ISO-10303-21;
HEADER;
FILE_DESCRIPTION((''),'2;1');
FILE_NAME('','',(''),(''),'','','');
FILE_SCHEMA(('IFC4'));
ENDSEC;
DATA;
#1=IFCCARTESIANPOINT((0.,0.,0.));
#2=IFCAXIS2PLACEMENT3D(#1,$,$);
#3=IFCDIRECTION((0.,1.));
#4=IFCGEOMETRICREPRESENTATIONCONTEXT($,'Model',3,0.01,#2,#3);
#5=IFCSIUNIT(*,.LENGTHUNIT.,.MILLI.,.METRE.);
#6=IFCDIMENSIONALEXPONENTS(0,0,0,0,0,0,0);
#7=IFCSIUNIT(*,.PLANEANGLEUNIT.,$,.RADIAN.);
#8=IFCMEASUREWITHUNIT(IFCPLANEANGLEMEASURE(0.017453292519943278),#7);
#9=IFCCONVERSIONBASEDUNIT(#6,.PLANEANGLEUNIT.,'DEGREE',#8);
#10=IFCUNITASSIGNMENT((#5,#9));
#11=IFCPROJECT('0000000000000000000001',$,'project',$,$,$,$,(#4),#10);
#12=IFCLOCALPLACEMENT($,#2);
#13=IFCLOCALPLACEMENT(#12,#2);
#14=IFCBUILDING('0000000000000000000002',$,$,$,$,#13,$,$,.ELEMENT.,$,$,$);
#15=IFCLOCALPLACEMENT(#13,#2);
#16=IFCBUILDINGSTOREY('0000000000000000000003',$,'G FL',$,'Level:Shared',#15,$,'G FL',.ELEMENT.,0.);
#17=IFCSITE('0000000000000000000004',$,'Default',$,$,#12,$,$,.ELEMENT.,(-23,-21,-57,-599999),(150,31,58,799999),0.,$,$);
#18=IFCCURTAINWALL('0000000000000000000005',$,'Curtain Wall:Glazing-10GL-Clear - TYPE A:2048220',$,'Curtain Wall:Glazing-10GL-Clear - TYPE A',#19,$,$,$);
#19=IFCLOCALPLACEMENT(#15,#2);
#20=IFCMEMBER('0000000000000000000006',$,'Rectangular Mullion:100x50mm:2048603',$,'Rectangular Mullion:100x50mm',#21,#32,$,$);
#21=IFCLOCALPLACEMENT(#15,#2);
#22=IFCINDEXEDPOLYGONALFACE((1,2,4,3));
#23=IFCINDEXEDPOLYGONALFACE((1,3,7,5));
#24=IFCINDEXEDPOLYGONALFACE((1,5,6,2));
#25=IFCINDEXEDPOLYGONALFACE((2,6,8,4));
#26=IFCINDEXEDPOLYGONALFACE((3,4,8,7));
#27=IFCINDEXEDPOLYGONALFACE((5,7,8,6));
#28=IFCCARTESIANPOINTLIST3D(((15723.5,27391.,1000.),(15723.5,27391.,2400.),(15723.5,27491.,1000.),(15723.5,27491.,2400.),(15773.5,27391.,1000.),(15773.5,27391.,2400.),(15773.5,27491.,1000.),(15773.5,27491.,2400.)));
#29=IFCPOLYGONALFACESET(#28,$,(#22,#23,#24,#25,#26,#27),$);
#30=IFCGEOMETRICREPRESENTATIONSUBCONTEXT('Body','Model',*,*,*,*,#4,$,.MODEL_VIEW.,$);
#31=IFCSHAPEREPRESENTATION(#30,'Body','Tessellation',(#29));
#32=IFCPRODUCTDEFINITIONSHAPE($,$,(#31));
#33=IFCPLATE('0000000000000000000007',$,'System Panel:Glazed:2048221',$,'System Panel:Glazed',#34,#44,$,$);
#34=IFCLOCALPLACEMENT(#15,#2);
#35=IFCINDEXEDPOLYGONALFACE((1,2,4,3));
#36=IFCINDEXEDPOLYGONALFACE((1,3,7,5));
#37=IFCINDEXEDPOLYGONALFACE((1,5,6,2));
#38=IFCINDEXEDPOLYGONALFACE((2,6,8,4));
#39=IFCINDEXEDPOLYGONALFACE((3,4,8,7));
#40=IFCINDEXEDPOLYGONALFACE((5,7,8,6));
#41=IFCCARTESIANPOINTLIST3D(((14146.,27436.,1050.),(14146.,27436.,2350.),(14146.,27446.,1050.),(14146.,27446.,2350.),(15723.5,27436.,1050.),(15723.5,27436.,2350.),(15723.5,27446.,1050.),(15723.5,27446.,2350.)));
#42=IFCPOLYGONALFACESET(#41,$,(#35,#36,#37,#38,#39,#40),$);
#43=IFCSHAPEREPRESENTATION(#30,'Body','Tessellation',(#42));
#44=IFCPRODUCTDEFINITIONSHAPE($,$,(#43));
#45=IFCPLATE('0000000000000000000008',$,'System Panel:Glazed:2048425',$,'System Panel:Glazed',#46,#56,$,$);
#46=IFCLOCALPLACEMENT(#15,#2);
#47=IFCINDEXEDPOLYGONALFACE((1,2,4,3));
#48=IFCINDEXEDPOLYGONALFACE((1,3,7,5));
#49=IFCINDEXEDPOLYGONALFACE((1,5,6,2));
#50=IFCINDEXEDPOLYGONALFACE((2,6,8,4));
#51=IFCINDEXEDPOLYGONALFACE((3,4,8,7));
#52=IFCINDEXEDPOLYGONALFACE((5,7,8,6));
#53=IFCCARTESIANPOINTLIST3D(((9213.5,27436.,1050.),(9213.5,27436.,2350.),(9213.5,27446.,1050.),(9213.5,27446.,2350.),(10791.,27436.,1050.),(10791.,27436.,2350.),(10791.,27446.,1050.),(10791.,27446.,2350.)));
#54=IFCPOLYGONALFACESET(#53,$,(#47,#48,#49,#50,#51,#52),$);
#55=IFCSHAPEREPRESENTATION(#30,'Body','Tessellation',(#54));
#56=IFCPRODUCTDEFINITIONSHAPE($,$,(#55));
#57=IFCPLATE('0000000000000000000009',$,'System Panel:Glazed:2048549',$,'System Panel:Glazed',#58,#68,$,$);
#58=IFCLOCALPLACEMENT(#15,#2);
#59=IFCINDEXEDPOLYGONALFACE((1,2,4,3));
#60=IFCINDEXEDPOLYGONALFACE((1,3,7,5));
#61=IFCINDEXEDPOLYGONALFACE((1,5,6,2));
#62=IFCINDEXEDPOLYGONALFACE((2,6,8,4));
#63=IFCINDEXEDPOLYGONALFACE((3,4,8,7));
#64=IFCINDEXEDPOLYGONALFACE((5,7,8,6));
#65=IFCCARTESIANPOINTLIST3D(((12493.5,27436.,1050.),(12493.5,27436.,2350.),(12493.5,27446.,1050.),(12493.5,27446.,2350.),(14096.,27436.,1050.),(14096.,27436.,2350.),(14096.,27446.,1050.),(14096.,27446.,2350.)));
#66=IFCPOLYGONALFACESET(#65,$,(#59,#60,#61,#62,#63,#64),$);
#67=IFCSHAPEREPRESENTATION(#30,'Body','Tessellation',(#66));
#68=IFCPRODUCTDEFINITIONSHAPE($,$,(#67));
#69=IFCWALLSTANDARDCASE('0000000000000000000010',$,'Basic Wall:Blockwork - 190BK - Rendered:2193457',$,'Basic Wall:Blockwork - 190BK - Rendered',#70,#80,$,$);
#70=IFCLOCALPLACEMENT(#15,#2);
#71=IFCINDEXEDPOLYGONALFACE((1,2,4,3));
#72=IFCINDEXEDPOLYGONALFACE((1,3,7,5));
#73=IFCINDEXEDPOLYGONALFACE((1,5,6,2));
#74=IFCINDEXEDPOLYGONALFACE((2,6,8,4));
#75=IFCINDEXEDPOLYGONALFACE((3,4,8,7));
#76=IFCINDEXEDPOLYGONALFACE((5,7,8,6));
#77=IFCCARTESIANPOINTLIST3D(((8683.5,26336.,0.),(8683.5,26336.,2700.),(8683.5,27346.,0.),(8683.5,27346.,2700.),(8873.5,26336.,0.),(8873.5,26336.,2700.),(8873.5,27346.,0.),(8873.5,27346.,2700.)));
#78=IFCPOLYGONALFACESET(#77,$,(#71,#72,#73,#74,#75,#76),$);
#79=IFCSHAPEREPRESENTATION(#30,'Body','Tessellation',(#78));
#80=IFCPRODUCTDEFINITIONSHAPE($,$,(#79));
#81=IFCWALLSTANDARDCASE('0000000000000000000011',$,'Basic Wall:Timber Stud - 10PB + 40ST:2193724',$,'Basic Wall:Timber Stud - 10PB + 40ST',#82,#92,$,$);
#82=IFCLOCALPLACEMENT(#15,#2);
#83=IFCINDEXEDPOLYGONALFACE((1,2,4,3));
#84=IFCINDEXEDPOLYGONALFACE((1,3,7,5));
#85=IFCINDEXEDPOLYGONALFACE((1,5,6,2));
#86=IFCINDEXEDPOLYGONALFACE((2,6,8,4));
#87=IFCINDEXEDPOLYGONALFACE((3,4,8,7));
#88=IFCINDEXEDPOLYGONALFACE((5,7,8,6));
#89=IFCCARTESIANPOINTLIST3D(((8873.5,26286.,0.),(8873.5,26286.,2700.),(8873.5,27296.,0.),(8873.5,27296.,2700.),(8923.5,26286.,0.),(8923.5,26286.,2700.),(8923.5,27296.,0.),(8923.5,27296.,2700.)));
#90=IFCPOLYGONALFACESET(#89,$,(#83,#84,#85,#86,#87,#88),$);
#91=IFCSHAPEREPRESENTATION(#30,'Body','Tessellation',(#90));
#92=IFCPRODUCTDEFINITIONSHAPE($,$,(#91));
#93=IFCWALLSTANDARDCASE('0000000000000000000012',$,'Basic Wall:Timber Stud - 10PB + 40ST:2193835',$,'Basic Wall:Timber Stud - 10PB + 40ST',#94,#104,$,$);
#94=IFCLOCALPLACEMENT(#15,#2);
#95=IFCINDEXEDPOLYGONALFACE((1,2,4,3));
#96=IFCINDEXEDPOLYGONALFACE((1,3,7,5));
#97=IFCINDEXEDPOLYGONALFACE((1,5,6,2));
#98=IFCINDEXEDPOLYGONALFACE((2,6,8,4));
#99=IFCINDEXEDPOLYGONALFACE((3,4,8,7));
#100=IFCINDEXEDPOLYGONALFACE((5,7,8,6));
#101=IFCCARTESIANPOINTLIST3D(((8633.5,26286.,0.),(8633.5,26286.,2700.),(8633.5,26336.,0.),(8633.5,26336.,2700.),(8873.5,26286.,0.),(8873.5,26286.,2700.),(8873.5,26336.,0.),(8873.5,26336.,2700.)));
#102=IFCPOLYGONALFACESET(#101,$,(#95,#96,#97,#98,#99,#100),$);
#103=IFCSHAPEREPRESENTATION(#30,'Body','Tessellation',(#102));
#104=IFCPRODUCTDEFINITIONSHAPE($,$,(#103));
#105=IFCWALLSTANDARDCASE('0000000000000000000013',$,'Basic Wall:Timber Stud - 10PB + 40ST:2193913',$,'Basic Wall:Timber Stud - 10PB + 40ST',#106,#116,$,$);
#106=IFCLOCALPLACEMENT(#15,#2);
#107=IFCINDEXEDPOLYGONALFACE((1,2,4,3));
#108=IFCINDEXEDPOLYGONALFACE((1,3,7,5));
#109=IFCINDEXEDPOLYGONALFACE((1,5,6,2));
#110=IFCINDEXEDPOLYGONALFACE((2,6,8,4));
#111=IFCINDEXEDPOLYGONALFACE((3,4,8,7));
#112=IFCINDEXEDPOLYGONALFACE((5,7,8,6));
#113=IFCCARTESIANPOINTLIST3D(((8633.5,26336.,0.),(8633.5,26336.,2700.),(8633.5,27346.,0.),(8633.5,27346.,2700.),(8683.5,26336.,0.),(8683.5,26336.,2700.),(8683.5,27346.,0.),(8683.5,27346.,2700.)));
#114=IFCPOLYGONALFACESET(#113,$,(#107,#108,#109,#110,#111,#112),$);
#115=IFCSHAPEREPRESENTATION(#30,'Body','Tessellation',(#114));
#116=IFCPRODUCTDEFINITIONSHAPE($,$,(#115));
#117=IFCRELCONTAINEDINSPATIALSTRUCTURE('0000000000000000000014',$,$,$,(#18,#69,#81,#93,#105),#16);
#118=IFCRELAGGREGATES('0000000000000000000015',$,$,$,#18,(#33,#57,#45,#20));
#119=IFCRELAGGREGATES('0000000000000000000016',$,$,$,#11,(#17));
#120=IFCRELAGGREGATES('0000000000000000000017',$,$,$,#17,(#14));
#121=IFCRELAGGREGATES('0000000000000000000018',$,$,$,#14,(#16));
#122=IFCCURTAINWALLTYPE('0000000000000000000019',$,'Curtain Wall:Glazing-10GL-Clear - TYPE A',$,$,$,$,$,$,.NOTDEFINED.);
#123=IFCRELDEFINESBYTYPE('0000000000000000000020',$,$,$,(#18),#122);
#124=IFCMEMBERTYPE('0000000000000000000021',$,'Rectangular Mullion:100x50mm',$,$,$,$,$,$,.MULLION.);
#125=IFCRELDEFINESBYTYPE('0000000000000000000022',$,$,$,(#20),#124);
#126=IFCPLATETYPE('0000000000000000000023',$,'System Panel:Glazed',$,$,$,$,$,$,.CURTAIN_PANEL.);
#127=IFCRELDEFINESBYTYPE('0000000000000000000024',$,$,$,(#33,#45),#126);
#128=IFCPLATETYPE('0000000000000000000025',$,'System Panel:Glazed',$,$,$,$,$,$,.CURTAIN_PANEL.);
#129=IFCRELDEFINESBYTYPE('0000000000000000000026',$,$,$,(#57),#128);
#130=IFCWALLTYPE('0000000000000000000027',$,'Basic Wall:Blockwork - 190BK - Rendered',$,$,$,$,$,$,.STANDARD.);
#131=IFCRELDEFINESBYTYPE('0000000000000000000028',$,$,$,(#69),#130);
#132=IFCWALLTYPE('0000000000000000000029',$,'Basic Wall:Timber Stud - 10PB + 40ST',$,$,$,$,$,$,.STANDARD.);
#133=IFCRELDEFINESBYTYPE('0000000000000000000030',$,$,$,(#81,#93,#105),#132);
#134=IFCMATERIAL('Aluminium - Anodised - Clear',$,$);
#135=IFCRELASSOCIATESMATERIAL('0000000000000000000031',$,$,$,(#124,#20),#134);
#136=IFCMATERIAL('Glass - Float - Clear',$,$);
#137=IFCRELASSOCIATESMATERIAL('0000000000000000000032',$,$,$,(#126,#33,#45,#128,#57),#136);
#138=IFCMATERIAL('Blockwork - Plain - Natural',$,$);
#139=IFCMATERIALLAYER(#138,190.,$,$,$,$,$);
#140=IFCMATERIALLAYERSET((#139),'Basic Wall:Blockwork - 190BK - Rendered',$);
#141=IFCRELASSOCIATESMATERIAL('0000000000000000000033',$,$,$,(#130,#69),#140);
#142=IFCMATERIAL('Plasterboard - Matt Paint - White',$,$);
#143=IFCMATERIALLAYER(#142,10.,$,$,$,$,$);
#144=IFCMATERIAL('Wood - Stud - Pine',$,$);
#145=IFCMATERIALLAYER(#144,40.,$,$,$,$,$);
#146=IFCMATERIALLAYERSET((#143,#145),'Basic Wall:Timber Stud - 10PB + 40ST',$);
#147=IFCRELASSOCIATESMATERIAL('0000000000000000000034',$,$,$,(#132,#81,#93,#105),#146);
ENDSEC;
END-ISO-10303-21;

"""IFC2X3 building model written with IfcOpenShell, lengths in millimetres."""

from ifc_helpers import new_model, entity, si_unit, converted_unit, direction, frame, frame_2d, origin, origin_2d_with_axis, place, context, subcontext, project, spatial, rectangle, extrude, source, transform, mapped, material, layer, layer_set, layer_usage, type_object, type_shapes, element, aggregate, save


model = new_model("IFC2X3")

# Units and contexts
model_context = context("Model", 3, precision=0.01, world=origin(), true_north=direction((0.0, 1.0)))
body_context = subcontext(model_context, "Body", "Model", "MODEL_VIEW")
ifc_project = project(units=[si_unit("LENGTHUNIT", "METRE", prefix="MILLI"), converted_unit("PLANEANGLEUNIT", "DEGREE", entity("IfcPlaneAngleMeasure", 0.017453292519943278), si_unit("PLANEANGLEUNIT", "RADIAN"), dimensions=[0, 0, 0, 0, 0, 0, 0])], contexts=[model_context])

# Site, building, storey
site_placement = place(None, origin())
site = spatial("IfcSite", under=ifc_project, at=site_placement, Name="Default", CompositionType="ELEMENT", RefLatitude=(-23, -21, -57, -599999), RefLongitude=(150, 31, 58, 799999), RefElevation=0.0)
building_placement = place(site_placement, origin())
building = spatial("IfcBuilding", under=site, at=building_placement, CompositionType="ELEMENT")
storey_placement = place(building_placement, origin())
storey = spatial("IfcBuildingStorey", under=building, at=storey_placement, Name="G FL", ObjectType="Level:Shared", LongName="G FL", CompositionType="ELEMENT", Elevation=0.0)

# Curtain wall, member, plates
curtain_wall_type = type_object("IfcCurtainWallType", Name="Curtain Wall:Glazing-10GL-Clear - TYPE A", PredefinedType="NOTDEFINED")
curtain_wall_placement = place(storey_placement, origin())
curtain_wall = element("IfcCurtainWall", 1, at=curtain_wall_placement, inside=storey, type_object=curtain_wall_type, Name="Curtain Wall:Glazing-10GL-Clear - TYPE A:2048220", ObjectType="Curtain Wall:Glazing-10GL-Clear - TYPE A")
ifc_material_1 = material(Name="Aluminium - Anodised - Clear")
member_type_1 = type_object("IfcMemberType", Name="Rectangular Mullion:100x50mm", PredefinedType="MULLION", material=ifc_material_1)
shared_shape_1 = source(origin(), body_context, "Body", "SweptSolid", [
    extrude(rectangle(XDim=50.0, YDim=100.0, at=frame_2d((0.0, 0.0), x_axis=(1.0, 0.0))), frame((-25.0, 0.0, -1400.0), z_axis=(0.0, 0.0, 1.0), x_axis=(-1.0, 0.0, 0.0)), (0.0, 0.0, 1.0), 1400.0),
])
type_shapes(member_type_1, [shared_shape_1])
member_1_placement = place(curtain_wall_placement, frame((15773.5, 27441.0, 2400.0)))
member_1 = element("IfcMember", 2, at=member_1_placement, type_object=member_type_1, material=ifc_material_1, Name="Rectangular Mullion:100x50mm:2048603", ObjectType="Rectangular Mullion:100x50mm", context=body_context, shape_type="MappedRepresentation", body=[
    mapped(shared_shape_1, transform((0.0, 0.0, 0.0), scale=1.0)),
])
ifc_material_2 = material(Name="Glass - Float - Clear")
plate_type_1 = type_object("IfcPlateType", Name="System Panel:Glazed", PredefinedType="CURTAIN_PANEL", material=ifc_material_2)
shared_shape_2 = source(origin(), body_context, "Body", "SweptSolid", [
    extrude(rectangle(XDim=10.0, YDim=1577.5, at=origin_2d_with_axis()), frame((0.0, 0.0, 0.0), z_axis=(0.0, 0.0, 1.0), x_axis=(0.0, 1.0, 0.0)), (0.0, 0.0, 1.0), 1300.0),
])
type_shapes(plate_type_1, [shared_shape_2])
plate_1_placement = place(curtain_wall_placement, frame((14934.8, 27441.0, 1050.0), z_axis=(0.0, 0.0, 1.0), x_axis=(-1.0, 0.0, 0.0)))
plate_1 = element("IfcPlate", 3, at=plate_1_placement, type_object=plate_type_1, material=ifc_material_2, Name="System Panel:Glazed:2048221", ObjectType="System Panel:Glazed", context=body_context, shape_type="MappedRepresentation", body=[
    mapped(shared_shape_2, transform((0.0, 0.0, 0.0), scale=1.0)),
])
plate_2_placement = place(curtain_wall_placement, frame((10002.3, 27441.0, 1050.0), z_axis=(0.0, 0.0, 1.0), x_axis=(-1.0, 0.0, 0.0)))
plate_2 = element("IfcPlate", 4, at=plate_2_placement, type_object=plate_type_1, material=ifc_material_2, Name="System Panel:Glazed:2048425", ObjectType="System Panel:Glazed", context=body_context, shape_type="MappedRepresentation", body=[
    mapped(shared_shape_2, transform((0.0, 0.0, 0.0), scale=1.0)),
])
plate_type_2 = type_object("IfcPlateType", Name="System Panel:Glazed", PredefinedType="CURTAIN_PANEL", material=ifc_material_2)
shared_shape_3 = source(origin(), body_context, "Body", "SweptSolid", [
    extrude(rectangle(XDim=10.0, YDim=1602.5, at=origin_2d_with_axis()), frame((0.0, 0.0, 0.0), z_axis=(0.0, 0.0, 1.0), x_axis=(0.0, 1.0, 0.0)), (0.0, 0.0, 1.0), 1300.0),
])
type_shapes(plate_type_2, [shared_shape_3])
plate_3_placement = place(curtain_wall_placement, frame((13294.8, 27441.0, 1050.0), z_axis=(0.0, 0.0, 1.0), x_axis=(-1.0, 0.0, 0.0)))
plate_3 = element("IfcPlate", 5, at=plate_3_placement, type_object=plate_type_2, material=ifc_material_2, Name="System Panel:Glazed:2048549", ObjectType="System Panel:Glazed", context=body_context, shape_type="MappedRepresentation", body=[
    mapped(shared_shape_3, transform((0.0, 0.0, 0.0), scale=1.0)),
])
aggregate(curtain_wall, [plate_1, plate_3, plate_2, member_1])

# Walls
ifc_material_3 = material(Name="Blockwork - Plain - Natural")
ifc_layer_1 = layer(ifc_material_3, 190.0)
ifc_layer_set_1 = layer_set([ifc_layer_1], Name="Basic Wall:Blockwork - 190BK - Rendered")
ifc_layer_usage_1 = layer_usage(ifc_layer_set_1, "AXIS2", "POSITIVE", -95.0)
wall_type_1 = type_object("IfcWallType", Name="Basic Wall:Blockwork - 190BK - Rendered", PredefinedType="STANDARD", material=ifc_layer_set_1)
wall_1_placement = place(storey_placement, frame((8778.5, 27346.0, 0.0), z_axis=(0.0, 0.0, 1.0), x_axis=(0.0, -1.0, 0.0)))
element("IfcWallStandardCase", 6, at=wall_1_placement, inside=storey, type_object=wall_type_1, material=ifc_layer_usage_1, Name="Basic Wall:Blockwork - 190BK - Rendered:2193457", ObjectType="Basic Wall:Blockwork - 190BK - Rendered", context=body_context, shape_type="SweptSolid", body=[
    extrude(rectangle(XDim=1010.0, YDim=190.0, at=frame_2d((505.0, 0.0), x_axis=(-1.0, 0.0))), origin(), (0.0, 0.0, 1.0), 2700.0),
])
ifc_material_4 = material(Name="Plasterboard - Matt Paint - White")
ifc_layer_2 = layer(ifc_material_4, 10.0)
ifc_material_5 = material(Name="Wood - Stud - Pine")
ifc_layer_3 = layer(ifc_material_5, 40.0)
ifc_layer_set_2 = layer_set([ifc_layer_2, ifc_layer_3], Name="Basic Wall:Timber Stud - 10PB + 40ST")
ifc_layer_usage_2 = layer_usage(ifc_layer_set_2, "AXIS2", "POSITIVE", -25.0)
wall_type_2 = type_object("IfcWallType", Name="Basic Wall:Timber Stud - 10PB + 40ST", PredefinedType="STANDARD", material=ifc_layer_set_2)
wall_2_placement = place(storey_placement, frame((8898.5, 26286.0, 0.0), z_axis=(0.0, 0.0, 1.0), x_axis=(0.0, 1.0, 0.0)))
element("IfcWallStandardCase", 7, at=wall_2_placement, inside=storey, type_object=wall_type_2, material=ifc_layer_usage_2, Name="Basic Wall:Timber Stud - 10PB + 40ST:2193724", ObjectType="Basic Wall:Timber Stud - 10PB + 40ST", context=body_context, shape_type="SweptSolid", body=[
    extrude(rectangle(XDim=1010.0, YDim=50.0, at=frame_2d((505.0, 0.0), x_axis=(-1.0, 0.0))), origin(), (0.0, 0.0, 1.0), 2700.0),
])
ifc_layer_usage_3 = layer_usage(ifc_layer_set_2, "AXIS2", "NEGATIVE", 25.0)
wall_3_placement = place(storey_placement, frame((8873.5, 26311.0, 0.0), z_axis=(0.0, 0.0, 1.0), x_axis=(-1.0, 0.0, 0.0)))
element("IfcWallStandardCase", 8, at=wall_3_placement, inside=storey, type_object=wall_type_2, material=ifc_layer_usage_3, Name="Basic Wall:Timber Stud - 10PB + 40ST:2193835", ObjectType="Basic Wall:Timber Stud - 10PB + 40ST", context=body_context, shape_type="SweptSolid", body=[
    extrude(rectangle(XDim=240.0, YDim=50.0, at=frame_2d((120.0, 0.0), x_axis=(-1.0, 0.0))), origin(), (0.0, 0.0, 1.0), 2700.0),
])
ifc_layer_usage_4 = layer_usage(ifc_layer_set_2, "AXIS2", "POSITIVE", -25.0)
wall_4_placement = place(storey_placement, frame((8658.5, 27346.0, 0.0), z_axis=(0.0, 0.0, 1.0), x_axis=(0.0, -1.0, 0.0)))
element("IfcWallStandardCase", 9, at=wall_4_placement, inside=storey, type_object=wall_type_2, material=ifc_layer_usage_4, Name="Basic Wall:Timber Stud - 10PB + 40ST:2193913", ObjectType="Basic Wall:Timber Stud - 10PB + 40ST", context=body_context, shape_type="SweptSolid", body=[
    extrude(rectangle(XDim=1010.0, YDim=50.0, at=frame_2d((505.0, 0.0), x_axis=(-1.0, 0.0))), origin(), (0.0, 0.0, 1.0), 2700.0),
])

save(model, "model.ifc")
